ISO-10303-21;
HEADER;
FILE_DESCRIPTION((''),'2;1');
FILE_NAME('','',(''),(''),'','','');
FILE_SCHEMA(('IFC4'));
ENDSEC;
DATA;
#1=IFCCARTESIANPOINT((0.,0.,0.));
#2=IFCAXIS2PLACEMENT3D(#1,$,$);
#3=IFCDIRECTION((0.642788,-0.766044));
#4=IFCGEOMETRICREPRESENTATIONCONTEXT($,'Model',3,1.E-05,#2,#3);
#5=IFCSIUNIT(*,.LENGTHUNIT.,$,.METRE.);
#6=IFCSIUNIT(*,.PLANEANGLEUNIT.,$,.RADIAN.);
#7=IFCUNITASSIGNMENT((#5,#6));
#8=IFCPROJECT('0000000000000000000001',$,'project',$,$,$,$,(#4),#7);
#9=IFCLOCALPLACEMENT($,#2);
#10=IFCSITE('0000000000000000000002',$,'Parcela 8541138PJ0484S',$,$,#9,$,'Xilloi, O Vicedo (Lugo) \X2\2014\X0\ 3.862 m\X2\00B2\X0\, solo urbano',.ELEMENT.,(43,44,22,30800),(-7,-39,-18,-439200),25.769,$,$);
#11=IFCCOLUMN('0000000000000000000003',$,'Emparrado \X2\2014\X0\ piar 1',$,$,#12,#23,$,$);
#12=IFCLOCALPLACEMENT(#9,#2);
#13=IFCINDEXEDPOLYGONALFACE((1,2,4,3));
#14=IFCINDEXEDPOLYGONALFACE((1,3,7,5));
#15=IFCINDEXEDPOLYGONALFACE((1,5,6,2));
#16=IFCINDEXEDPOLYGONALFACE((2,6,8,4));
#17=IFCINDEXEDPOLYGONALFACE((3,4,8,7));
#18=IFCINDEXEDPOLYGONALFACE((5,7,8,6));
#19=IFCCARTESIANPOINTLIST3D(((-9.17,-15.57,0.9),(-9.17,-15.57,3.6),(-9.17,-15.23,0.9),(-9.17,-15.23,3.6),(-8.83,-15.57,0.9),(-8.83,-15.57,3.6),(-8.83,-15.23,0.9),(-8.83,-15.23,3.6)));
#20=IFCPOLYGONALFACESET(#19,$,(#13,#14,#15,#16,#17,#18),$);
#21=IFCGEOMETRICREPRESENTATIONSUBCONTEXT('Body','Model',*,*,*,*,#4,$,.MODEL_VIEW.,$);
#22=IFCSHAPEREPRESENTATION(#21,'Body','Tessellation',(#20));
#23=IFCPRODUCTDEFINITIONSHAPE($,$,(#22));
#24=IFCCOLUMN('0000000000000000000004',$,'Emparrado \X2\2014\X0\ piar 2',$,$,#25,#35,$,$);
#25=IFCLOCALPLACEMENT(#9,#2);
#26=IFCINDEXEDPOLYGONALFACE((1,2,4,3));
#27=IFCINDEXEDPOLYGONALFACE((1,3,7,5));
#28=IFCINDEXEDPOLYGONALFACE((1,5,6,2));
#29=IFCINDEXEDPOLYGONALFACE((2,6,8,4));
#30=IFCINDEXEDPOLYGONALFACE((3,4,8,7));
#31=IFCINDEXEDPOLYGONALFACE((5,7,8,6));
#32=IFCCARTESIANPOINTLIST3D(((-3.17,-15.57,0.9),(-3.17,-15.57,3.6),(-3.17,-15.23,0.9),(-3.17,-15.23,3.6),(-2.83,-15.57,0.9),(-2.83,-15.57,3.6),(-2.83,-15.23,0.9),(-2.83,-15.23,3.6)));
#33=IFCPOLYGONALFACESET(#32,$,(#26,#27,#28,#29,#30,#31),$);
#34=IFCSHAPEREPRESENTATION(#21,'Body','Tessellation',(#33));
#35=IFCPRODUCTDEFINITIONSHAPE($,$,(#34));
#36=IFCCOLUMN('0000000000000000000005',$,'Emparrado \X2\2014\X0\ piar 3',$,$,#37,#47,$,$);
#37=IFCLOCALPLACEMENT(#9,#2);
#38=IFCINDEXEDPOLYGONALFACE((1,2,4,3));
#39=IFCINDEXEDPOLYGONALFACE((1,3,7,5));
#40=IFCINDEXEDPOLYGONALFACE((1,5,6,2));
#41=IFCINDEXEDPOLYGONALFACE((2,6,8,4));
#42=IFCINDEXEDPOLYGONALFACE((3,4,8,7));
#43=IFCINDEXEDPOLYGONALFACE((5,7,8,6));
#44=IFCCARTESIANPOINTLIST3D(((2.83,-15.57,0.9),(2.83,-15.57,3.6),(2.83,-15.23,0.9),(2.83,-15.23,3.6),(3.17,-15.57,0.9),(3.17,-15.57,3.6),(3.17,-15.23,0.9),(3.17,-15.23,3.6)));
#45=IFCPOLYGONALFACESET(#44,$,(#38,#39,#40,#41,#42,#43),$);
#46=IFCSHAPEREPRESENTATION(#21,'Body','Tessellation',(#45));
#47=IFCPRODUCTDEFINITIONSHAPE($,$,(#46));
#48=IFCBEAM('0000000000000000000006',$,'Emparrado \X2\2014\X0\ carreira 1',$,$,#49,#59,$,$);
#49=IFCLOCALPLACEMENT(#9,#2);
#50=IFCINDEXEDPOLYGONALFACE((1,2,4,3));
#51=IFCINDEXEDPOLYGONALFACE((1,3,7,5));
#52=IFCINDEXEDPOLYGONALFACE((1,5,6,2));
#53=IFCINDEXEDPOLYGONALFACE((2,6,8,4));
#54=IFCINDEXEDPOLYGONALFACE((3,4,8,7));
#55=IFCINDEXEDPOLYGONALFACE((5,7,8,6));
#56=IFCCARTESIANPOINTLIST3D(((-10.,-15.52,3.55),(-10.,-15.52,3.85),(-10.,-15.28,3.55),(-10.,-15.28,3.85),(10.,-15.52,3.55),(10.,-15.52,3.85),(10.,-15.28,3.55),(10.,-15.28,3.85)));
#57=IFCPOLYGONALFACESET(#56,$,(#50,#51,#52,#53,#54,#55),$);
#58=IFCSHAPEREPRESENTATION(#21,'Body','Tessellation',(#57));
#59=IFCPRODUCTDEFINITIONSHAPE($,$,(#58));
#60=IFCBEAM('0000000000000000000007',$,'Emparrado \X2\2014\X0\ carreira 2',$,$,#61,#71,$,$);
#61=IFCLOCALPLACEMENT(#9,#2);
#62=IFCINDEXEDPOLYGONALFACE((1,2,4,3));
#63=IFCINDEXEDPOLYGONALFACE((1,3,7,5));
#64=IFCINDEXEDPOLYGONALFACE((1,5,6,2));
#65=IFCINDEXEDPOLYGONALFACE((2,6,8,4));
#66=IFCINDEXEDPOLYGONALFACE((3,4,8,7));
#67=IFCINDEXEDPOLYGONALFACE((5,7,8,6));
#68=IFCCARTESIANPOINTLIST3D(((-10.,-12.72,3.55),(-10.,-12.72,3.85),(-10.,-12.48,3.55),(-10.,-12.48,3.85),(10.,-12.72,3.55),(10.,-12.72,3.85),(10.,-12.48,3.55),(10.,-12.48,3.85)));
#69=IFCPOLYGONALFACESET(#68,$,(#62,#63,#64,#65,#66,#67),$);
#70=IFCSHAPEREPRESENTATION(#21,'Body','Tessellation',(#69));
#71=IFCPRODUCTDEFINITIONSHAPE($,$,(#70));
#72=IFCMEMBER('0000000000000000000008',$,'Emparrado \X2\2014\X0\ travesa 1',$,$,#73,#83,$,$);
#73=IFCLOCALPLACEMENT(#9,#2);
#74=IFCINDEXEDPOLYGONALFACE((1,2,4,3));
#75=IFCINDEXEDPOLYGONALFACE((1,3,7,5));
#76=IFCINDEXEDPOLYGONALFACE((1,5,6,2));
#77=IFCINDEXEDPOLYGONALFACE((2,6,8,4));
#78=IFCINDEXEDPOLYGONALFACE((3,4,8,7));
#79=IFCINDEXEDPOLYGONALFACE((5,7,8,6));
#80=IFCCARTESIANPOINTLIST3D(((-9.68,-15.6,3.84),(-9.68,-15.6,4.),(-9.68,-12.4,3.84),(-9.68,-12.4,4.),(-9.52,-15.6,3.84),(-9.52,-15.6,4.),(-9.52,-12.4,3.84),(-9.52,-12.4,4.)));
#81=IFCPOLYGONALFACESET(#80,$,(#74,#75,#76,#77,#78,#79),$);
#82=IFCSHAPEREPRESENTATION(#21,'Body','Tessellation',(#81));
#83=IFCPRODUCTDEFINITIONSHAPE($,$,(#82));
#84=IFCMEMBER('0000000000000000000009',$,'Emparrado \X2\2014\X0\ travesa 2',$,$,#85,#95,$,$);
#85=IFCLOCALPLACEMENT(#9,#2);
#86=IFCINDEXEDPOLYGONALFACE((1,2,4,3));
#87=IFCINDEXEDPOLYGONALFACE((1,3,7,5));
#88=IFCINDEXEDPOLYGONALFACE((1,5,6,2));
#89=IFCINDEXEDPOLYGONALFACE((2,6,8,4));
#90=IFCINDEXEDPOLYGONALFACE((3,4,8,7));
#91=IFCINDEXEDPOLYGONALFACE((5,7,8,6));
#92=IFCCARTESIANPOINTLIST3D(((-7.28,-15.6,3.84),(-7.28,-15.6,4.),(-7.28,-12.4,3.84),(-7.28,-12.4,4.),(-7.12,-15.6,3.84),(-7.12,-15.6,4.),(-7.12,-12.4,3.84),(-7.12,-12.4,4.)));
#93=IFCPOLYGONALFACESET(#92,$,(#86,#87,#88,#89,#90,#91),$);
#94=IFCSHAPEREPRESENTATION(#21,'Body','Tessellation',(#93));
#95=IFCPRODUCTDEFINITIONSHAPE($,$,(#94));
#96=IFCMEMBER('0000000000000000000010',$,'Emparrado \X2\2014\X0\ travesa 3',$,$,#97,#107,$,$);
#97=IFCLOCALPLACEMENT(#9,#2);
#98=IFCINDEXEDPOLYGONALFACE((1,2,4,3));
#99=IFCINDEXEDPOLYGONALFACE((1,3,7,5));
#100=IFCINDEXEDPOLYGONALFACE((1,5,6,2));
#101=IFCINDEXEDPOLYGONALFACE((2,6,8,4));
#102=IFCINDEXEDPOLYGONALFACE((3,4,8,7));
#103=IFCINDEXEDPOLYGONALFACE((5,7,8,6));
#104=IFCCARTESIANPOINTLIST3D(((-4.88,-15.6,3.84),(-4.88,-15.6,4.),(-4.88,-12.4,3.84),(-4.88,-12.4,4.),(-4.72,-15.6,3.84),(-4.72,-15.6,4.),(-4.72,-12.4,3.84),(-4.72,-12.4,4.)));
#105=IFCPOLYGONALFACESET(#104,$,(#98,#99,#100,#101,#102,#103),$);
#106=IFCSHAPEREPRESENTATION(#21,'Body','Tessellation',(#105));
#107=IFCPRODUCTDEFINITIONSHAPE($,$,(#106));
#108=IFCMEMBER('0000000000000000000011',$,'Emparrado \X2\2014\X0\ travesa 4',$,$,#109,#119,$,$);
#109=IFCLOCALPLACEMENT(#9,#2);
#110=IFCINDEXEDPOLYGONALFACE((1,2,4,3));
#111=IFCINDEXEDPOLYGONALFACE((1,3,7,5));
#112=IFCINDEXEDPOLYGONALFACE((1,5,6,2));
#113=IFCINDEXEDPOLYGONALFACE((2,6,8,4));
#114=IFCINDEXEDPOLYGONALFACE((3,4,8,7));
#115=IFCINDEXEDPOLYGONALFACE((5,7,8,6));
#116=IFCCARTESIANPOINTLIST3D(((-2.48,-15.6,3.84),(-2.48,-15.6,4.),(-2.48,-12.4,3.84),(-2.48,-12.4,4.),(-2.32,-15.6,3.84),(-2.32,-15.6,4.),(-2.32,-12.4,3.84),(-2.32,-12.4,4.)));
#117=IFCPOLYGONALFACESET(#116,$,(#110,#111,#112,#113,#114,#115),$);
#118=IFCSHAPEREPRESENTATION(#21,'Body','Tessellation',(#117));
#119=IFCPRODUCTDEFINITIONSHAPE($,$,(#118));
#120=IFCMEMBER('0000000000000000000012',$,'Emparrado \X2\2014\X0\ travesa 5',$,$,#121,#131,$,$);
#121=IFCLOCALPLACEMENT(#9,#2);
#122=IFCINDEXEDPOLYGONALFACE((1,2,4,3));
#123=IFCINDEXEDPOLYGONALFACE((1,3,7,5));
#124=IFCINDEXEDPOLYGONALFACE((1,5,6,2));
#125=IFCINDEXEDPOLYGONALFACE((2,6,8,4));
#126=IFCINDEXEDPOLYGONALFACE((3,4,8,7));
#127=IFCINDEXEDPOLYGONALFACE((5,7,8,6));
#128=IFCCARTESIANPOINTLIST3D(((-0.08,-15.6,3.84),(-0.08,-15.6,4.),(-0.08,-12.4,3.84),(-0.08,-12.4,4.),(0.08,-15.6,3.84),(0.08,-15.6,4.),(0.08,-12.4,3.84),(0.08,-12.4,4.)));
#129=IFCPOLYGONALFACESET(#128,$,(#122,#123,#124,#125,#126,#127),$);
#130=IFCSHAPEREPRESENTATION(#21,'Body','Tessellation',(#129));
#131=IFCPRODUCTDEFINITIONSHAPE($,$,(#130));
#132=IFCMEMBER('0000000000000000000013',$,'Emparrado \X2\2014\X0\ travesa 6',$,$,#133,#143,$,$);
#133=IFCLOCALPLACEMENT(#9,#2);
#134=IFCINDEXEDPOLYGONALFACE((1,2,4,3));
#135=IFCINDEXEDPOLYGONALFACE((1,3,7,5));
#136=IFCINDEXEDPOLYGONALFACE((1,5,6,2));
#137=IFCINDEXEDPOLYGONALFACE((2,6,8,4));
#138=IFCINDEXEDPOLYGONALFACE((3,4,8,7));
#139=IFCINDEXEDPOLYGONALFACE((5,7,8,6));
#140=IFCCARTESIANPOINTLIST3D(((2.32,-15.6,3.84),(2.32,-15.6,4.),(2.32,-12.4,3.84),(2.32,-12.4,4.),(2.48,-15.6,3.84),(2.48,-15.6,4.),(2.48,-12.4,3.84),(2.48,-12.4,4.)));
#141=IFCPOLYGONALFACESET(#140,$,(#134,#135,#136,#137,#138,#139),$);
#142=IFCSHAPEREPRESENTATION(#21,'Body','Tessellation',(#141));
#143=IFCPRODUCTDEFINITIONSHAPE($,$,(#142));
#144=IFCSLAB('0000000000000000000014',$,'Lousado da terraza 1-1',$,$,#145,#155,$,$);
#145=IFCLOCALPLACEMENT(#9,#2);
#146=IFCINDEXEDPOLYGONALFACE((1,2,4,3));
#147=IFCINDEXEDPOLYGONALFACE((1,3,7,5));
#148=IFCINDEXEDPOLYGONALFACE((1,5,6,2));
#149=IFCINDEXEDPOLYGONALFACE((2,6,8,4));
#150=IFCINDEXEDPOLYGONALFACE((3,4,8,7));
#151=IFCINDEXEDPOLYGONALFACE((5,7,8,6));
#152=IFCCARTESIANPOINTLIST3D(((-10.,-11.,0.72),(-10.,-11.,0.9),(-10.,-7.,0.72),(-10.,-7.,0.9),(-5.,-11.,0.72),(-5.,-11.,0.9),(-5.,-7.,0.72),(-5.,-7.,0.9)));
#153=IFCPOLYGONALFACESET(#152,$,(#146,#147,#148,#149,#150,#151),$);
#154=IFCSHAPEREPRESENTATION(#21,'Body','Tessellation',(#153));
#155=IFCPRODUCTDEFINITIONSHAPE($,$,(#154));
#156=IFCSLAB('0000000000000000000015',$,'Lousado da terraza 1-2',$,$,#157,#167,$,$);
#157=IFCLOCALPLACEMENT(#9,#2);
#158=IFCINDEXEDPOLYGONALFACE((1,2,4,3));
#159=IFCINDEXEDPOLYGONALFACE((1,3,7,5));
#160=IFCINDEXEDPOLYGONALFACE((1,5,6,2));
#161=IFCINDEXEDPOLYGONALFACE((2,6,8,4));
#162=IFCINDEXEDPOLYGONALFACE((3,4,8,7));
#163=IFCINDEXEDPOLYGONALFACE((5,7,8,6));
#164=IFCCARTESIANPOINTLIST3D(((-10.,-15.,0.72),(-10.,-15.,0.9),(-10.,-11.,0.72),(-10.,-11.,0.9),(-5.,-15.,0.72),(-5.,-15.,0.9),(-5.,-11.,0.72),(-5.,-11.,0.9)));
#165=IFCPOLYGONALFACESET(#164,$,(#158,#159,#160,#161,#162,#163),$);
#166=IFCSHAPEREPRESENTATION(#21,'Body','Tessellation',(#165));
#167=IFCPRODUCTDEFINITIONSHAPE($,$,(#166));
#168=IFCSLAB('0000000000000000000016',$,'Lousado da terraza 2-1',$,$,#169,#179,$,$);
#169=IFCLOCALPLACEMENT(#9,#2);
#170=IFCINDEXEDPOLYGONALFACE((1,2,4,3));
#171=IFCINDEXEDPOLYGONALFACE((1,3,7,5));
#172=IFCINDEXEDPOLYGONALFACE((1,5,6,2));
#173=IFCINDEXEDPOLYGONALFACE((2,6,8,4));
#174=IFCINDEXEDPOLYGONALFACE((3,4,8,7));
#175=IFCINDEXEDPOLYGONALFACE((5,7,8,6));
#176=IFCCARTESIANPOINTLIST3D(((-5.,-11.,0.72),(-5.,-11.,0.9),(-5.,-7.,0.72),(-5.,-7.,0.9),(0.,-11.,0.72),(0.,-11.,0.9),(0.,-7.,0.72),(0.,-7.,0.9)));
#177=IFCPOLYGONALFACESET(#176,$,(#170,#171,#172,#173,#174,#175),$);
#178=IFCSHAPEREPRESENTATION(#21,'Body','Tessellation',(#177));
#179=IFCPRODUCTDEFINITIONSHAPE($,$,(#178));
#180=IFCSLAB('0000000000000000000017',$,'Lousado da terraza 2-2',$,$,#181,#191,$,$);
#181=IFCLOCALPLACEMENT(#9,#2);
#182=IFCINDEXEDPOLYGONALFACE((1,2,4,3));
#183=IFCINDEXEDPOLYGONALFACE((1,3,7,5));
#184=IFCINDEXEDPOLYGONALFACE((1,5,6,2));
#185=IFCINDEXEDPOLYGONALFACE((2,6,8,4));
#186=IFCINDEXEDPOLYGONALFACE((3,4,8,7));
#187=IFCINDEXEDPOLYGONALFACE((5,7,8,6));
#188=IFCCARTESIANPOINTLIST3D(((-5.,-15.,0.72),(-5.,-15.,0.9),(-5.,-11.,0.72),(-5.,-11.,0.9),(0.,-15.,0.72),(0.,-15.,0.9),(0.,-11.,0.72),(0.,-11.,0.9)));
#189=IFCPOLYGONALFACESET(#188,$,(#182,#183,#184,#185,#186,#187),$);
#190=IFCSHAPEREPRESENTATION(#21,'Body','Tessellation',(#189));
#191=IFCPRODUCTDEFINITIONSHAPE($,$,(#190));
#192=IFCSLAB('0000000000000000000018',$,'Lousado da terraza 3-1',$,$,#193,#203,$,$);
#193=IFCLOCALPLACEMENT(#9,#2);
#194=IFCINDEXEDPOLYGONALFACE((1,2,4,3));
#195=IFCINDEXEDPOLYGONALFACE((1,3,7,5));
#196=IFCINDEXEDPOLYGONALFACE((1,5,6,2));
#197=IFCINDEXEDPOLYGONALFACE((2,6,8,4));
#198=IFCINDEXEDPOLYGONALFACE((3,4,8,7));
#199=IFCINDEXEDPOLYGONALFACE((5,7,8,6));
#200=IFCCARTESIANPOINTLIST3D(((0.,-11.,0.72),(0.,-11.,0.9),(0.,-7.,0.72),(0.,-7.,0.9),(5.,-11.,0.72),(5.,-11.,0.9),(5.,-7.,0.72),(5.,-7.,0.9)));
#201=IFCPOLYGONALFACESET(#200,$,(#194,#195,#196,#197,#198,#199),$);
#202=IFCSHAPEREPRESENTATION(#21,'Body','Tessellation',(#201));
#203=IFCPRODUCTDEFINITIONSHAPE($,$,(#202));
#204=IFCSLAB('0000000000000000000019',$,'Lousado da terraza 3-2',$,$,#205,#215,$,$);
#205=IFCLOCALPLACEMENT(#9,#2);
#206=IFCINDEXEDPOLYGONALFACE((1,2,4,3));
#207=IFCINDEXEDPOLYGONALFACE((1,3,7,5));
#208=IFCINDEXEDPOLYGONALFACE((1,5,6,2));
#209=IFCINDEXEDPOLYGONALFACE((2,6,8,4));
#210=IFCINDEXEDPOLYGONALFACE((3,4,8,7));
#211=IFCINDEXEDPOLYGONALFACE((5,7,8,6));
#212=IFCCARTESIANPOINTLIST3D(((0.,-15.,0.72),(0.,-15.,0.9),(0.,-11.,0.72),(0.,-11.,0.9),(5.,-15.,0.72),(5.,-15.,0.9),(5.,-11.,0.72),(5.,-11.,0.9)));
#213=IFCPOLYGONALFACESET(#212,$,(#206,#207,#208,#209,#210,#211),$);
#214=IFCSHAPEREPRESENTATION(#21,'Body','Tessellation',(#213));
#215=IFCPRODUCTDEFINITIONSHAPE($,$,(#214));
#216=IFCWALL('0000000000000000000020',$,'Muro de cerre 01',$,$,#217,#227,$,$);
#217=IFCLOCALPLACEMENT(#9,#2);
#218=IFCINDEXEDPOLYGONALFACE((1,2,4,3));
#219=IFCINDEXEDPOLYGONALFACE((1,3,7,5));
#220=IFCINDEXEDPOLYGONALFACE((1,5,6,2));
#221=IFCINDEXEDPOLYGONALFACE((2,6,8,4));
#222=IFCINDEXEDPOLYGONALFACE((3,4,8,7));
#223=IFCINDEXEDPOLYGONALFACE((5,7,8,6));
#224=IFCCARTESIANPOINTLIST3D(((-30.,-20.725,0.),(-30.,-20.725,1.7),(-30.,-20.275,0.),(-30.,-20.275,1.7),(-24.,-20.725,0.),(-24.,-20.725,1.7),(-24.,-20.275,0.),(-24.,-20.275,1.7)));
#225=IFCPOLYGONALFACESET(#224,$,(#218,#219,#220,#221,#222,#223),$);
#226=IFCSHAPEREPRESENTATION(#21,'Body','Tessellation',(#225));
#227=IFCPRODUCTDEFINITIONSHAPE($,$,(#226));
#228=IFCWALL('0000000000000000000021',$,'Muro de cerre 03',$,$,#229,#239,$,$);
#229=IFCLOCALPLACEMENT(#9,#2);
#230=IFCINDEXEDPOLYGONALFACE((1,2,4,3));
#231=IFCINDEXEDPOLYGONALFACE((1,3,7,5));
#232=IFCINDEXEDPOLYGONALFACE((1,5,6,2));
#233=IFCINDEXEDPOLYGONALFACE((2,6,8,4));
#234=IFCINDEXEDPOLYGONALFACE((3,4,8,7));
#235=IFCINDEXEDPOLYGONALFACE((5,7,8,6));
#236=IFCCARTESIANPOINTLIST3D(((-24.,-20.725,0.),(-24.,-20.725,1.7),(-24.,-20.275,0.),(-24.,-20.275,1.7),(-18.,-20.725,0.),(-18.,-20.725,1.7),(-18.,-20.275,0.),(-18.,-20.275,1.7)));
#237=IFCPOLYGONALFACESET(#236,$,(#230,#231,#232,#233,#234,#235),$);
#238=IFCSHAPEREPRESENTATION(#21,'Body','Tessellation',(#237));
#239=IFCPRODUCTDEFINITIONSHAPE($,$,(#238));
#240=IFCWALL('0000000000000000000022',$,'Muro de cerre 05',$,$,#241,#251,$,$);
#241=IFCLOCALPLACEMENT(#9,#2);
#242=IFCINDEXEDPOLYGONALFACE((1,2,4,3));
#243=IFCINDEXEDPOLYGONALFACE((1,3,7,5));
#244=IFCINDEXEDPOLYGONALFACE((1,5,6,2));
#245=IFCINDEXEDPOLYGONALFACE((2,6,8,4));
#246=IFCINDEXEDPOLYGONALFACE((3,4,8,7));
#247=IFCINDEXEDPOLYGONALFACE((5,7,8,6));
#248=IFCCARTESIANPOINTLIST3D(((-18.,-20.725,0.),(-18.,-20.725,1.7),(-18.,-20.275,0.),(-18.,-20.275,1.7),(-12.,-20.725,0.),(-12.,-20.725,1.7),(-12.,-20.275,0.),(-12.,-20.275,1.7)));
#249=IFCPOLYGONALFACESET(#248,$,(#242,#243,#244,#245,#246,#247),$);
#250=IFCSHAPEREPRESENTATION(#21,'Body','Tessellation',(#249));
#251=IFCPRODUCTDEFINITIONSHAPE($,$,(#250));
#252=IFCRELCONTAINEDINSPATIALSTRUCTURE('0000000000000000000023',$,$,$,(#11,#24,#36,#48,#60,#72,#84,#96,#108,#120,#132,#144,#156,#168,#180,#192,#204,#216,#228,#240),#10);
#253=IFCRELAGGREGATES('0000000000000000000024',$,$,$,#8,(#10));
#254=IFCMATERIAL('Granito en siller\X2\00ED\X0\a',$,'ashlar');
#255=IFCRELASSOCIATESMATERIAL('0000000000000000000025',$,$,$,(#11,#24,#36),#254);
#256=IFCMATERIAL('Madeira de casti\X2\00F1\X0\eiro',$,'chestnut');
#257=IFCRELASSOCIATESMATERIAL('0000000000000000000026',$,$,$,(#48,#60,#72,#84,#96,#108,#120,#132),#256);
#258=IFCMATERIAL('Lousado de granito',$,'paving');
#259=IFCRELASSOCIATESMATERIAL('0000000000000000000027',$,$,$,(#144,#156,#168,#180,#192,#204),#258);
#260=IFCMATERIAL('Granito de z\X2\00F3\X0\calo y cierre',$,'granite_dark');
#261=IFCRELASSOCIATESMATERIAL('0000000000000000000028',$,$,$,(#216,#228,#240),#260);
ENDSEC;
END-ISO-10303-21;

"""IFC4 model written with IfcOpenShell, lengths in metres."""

from ifc_helpers import new_model, si_unit, direction, frame, origin, origin_2d, place, context, subcontext, project, spatial, rectangle, extrude, material, element, save


model = new_model("IFC4")

# Units and contexts
model_context = context("Model", 3, precision=1e-05, world=origin(), true_north=direction((0.642788, -0.766044)))
body_context = subcontext(model_context, "Body", "Model", "MODEL_VIEW")
ifc_project = project(units=[si_unit("LENGTHUNIT", "METRE"), si_unit("PLANEANGLEUNIT", "RADIAN")], contexts=[model_context])

# Site
site_placement = place(None, origin())
site = spatial("IfcSite", under=ifc_project, at=site_placement, Name="Parcela 8541138PJ0484S", LongName="Xilloi, O Vicedo (Lugo) — 3.862 m², solo urbano", CompositionType="ELEMENT", RefLatitude=(43, 44, 22, 30800), RefLongitude=(-7, -39, -18, -439200), RefElevation=25.769)

# Columns
ifc_material_1 = material(Name="Granito en sillería", Category="ashlar")
for number, where, name in (
    (1, (-9.0, -15.4, 2.25), "Emparrado — piar 1"),
    (2, (-3.0, -15.4, 2.25), "Emparrado — piar 2"),
    (3, (3.0, -15.4, 2.25), "Emparrado — piar 3"),
):
    element("IfcColumn", number, at=place(site_placement, frame(where)), inside=site, material=ifc_material_1, Name=name, context=body_context, shape_type="SweptSolid", body=[
        extrude(rectangle(XDim=0.34, YDim=0.34, at=origin_2d()), frame((0.0, 0.0, -1.35)), (0.0, 0.0, 1.0), 2.7),
    ])

# Beams
ifc_material_2 = material(Name="Madeira de castiñeiro", Category="chestnut")
for number, where, name in (
    (4, (0.0, -15.4, 3.7), "Emparrado — carreira 1"),
    (5, (0.0, -12.6, 3.7), "Emparrado — carreira 2"),
):
    element("IfcBeam", number, at=place(site_placement, frame(where)), inside=site, material=ifc_material_2, Name=name, context=body_context, shape_type="SweptSolid", body=[
        extrude(rectangle(XDim=20.0, YDim=0.24, at=origin_2d()), frame((0.0, 0.0, -0.15)), (0.0, 0.0, 1.0), 0.3),
    ])

# Members
for number, where, name in (
    (6, (-9.6, -14.0, 3.92), "Emparrado — travesa 1"),
    (7, (-7.2, -14.0, 3.92), "Emparrado — travesa 2"),
    (8, (-4.8, -14.0, 3.92), "Emparrado — travesa 3"),
    (9, (-2.4, -14.0, 3.92), "Emparrado — travesa 4"),
    (10, (0.0, -14.0, 3.92), "Emparrado — travesa 5"),
    (11, (2.4, -14.0, 3.92), "Emparrado — travesa 6"),
):
    element("IfcMember", number, at=place(site_placement, frame(where)), inside=site, material=ifc_material_2, Name=name, context=body_context, shape_type="SweptSolid", body=[
        extrude(rectangle(XDim=0.16, YDim=3.2, at=origin_2d()), frame((0.0, 0.0, -0.08)), (0.0, 0.0, 1.0), 0.16),
    ])

# Slabs
ifc_material_3 = material(Name="Lousado de granito", Category="paving")
for number, where, name in (
    (12, (-7.5, -9.0, 0.81), "Lousado da terraza 1-1"),
    (13, (-7.5, -13.0, 0.81), "Lousado da terraza 1-2"),
    (14, (-2.5, -9.0, 0.81), "Lousado da terraza 2-1"),
    (15, (-2.5, -13.0, 0.81), "Lousado da terraza 2-2"),
    (16, (2.5, -9.0, 0.81), "Lousado da terraza 3-1"),
    (17, (2.5, -13.0, 0.81), "Lousado da terraza 3-2"),
):
    element("IfcSlab", number, at=place(site_placement, frame(where)), inside=site, material=ifc_material_3, Name=name, context=body_context, shape_type="SweptSolid", body=[
        extrude(rectangle(XDim=5.0, YDim=4.0, at=origin_2d()), frame((0.0, 0.0, -0.09)), (0.0, 0.0, 1.0), 0.18),
    ])

# Walls
ifc_material_4 = material(Name="Granito de zócalo y cierre", Category="granite_dark")
for number, where, name in (
    (18, (-27.0, -20.5, 0.85), "Muro de cerre 01"),
    (19, (-21.0, -20.5, 0.85), "Muro de cerre 03"),
    (20, (-15.0, -20.5, 0.85), "Muro de cerre 05"),
):
    element("IfcWall", number, at=place(site_placement, frame(where)), inside=site, material=ifc_material_4, Name=name, context=body_context, shape_type="SweptSolid", body=[
        extrude(rectangle(XDim=6.0, YDim=0.45, at=origin_2d()), frame((0.0, 0.0, -0.85)), (0.0, 0.0, 1.0), 1.7),
    ])

save(model, "model.ifc")
